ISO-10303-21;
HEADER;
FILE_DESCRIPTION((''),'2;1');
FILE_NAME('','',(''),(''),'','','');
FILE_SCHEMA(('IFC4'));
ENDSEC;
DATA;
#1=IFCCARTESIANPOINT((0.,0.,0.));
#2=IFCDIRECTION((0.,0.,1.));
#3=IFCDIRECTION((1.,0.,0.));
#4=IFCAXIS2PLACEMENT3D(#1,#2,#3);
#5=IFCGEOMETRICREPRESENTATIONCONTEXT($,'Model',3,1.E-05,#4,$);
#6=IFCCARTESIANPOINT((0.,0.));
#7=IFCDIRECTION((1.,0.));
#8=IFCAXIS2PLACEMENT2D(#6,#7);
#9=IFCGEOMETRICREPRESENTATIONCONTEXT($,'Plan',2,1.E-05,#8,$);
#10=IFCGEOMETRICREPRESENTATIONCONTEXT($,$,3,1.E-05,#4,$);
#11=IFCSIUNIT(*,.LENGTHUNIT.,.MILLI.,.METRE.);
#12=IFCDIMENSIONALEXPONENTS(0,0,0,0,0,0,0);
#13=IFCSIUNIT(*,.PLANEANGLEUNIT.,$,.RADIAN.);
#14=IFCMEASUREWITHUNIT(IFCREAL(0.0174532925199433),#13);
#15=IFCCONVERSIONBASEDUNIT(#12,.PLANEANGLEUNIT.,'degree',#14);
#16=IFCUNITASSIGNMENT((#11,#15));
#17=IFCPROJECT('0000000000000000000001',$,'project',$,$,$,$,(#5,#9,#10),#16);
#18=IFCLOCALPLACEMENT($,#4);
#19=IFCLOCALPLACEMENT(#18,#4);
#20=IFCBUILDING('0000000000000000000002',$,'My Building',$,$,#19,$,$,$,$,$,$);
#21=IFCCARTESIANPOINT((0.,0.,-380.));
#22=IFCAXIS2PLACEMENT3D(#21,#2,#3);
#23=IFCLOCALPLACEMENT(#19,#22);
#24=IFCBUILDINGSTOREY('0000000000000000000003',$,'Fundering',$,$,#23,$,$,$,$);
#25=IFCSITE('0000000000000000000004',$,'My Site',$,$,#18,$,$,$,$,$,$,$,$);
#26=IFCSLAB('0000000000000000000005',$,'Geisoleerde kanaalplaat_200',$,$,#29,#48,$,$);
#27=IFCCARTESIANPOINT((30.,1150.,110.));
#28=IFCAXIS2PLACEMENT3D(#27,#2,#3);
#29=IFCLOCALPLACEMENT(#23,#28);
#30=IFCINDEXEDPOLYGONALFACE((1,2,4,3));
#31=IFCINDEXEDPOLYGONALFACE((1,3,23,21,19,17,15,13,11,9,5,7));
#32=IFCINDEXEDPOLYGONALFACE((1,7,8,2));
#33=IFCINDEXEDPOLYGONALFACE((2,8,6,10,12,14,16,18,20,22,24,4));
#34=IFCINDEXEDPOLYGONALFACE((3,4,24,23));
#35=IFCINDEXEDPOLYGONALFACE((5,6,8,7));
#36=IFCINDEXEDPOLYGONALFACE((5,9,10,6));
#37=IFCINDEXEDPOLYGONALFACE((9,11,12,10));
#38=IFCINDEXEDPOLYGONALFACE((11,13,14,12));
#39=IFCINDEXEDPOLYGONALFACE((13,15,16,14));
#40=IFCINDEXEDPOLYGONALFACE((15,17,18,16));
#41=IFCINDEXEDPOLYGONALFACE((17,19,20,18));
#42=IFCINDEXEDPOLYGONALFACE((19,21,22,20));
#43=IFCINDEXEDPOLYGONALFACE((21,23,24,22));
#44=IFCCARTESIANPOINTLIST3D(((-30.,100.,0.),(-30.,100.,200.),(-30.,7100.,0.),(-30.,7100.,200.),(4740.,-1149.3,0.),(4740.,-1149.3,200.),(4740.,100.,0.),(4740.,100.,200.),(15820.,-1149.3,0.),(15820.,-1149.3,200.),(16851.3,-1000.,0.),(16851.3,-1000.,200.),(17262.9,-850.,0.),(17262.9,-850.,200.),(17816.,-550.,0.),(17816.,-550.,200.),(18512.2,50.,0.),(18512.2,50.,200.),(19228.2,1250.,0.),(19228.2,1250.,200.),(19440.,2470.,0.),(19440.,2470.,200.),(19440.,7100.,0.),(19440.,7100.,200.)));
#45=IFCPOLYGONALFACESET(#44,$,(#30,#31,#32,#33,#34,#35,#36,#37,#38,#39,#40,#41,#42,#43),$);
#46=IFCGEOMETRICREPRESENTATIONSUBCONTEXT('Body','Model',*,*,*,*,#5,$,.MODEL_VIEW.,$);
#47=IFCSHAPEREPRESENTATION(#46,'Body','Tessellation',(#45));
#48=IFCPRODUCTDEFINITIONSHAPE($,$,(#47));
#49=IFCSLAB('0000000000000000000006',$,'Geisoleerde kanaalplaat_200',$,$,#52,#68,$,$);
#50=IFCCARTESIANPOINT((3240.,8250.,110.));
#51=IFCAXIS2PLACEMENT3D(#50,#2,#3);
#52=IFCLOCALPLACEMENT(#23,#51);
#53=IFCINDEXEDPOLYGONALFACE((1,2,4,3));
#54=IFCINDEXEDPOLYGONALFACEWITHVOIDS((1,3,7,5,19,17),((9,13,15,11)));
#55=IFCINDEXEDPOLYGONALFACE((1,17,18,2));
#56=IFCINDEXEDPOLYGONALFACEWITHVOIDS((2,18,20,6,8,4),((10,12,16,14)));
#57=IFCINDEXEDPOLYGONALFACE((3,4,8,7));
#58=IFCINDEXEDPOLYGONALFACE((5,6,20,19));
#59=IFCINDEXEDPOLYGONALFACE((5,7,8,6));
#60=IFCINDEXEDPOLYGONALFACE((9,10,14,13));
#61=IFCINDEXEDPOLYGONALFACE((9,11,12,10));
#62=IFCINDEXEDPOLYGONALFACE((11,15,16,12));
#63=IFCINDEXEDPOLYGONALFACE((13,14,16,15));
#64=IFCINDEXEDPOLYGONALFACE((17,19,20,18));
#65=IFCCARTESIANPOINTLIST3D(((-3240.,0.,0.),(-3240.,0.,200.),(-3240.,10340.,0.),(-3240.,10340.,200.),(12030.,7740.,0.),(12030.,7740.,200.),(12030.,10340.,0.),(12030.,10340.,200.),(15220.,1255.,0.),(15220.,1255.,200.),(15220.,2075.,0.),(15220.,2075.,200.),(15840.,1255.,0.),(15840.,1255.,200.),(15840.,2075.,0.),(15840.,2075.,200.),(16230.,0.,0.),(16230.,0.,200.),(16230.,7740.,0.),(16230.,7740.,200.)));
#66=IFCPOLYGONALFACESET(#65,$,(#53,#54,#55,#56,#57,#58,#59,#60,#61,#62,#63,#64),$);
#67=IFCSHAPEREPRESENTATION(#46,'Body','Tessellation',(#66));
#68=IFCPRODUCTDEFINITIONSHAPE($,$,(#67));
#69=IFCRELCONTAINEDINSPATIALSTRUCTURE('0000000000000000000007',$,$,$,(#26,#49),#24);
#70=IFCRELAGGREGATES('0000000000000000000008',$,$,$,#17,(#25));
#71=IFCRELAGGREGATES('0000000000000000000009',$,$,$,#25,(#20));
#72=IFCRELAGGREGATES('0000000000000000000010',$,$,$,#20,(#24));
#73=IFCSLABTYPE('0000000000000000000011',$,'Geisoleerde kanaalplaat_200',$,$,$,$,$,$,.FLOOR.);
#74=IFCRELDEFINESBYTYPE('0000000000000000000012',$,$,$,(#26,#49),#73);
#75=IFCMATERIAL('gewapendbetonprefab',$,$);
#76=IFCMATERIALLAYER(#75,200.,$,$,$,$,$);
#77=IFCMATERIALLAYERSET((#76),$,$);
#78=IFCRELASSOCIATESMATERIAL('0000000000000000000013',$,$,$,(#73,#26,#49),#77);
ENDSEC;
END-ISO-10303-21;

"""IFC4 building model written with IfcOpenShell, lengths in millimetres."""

from ifc_helpers import new_model, entity, si_unit, converted_unit, frame, origin_with_axes, origin_2d_with_axis, place, context, subcontext, project, spatial, line, indexed_curve, outline, extrude, material, layer, layer_set, layer_usage, type_object, element, save


model = new_model("IFC4")

# Units and contexts
model_context = context("Model", 3, precision=1e-05, world=origin_with_axes())
plan_context = context("Plan", 2, precision=1e-05, world=origin_2d_with_axis())
context_of_model = context(None, 3, precision=1e-05, world=origin_with_axes())
body_context = subcontext(model_context, "Body", "Model", "MODEL_VIEW")
ifc_project = project(units=[si_unit("LENGTHUNIT", "METRE", prefix="MILLI"), converted_unit("PLANEANGLEUNIT", "degree", entity("IfcReal", 0.0174532925199433), si_unit("PLANEANGLEUNIT", "RADIAN"), dimensions=[0, 0, 0, 0, 0, 0, 0])], contexts=[model_context, plan_context, context_of_model])

# Site, building, storey
site_placement = place(None, origin_with_axes())
site = spatial("IfcSite", under=ifc_project, at=site_placement, Name="My Site")
building_placement = place(site_placement, origin_with_axes())
building = spatial("IfcBuilding", under=site, at=building_placement, Name="My Building")
storey_placement = place(building_placement, frame((0.0, 0.0, -380.0), z_axis=(0.0, 0.0, 1.0), x_axis=(1.0, 0.0, 0.0)))
storey = spatial("IfcBuildingStorey", under=building, at=storey_placement, Name="Fundering")

# Shared definitions
ifc_material_1 = material(Name="gewapendbetonprefab")

# Slabs
ifc_layer = layer(ifc_material_1, 200.0)
ifc_layer_set = layer_set([ifc_layer])
ifc_layer_usage_1 = layer_usage(ifc_layer_set, "AXIS3", "POSITIVE", 0.0)
slab_type = type_object("IfcSlabType", Name="Geisoleerde kanaalplaat_200", PredefinedType="FLOOR", material=ifc_layer_set)
slab_1_placement = place(storey_placement, frame((30.0, 1150.0, 110.0), z_axis=(0.0, 0.0, 1.0), x_axis=(1.0, 0.0, 0.0)))
element("IfcSlab", 1, at=slab_1_placement, inside=storey, type_object=slab_type, material=ifc_layer_usage_1, Name="Geisoleerde kanaalplaat_200", context=body_context, shape_type="SweptSolid", body=[
    extrude(outline(indexed_curve([(4740.0, -1149.3), (15820.0, -1149.3), (16851.3, -1000.0), (17262.9, -850.0), (17816.0, -550.0), (18512.2, 50.0), (19228.2, 1250.0), (19440.0, 2470.0), (19440.0, 7100.0), (-30.0, 7100.0), (-30.0, 100.0), (4740.0, 100.0)], segments=[line(2, 1), line(1, 12), line(12, 11), line(11, 10), line(10, 9), line(9, 8), line(8, 7), line(7, 6), line(6, 5), line(5, 4), line(4, 3), line(3, 2)], self_intersect=False)), None, (0.0, 0.0, 1.0), 200.0),
])
ifc_layer_usage_2 = layer_usage(ifc_layer_set, "AXIS3", "POSITIVE", 0.0)
slab_2_placement = place(storey_placement, frame((3240.0, 8250.0, 110.0), z_axis=(0.0, 0.0, 1.0), x_axis=(1.0, 0.0, 0.0)))
element("IfcSlab", 2, at=slab_2_placement, inside=storey, type_object=slab_type, material=ifc_layer_usage_2, Name="Geisoleerde kanaalplaat_200", context=body_context, shape_type="SweptSolid", body=[
    extrude(outline(indexed_curve([(16230.0, 0.0), (-3240.0, 0.0), (-3240.0, 10340.0), (12030.0, 10340.0), (12030.0, 7740.0), (16230.0, 7740.0), (15840.0, 1255.0), (15220.0, 1255.0), (15220.0, 2075.0), (15840.0, 2075.0)], segments=[line(1, 6), line(6, 5), line(5, 4), line(4, 3), line(3, 2), line(2, 1)], self_intersect=False), holes=[indexed_curve([(16230.0, 0.0), (-3240.0, 0.0), (-3240.0, 10340.0), (12030.0, 10340.0), (12030.0, 7740.0), (16230.0, 7740.0), (15840.0, 1255.0), (15220.0, 1255.0), (15220.0, 2075.0), (15840.0, 2075.0)], segments=[line(8, 7), line(7, 10), line(10, 9), line(9, 8)], self_intersect=False)]), None, (0.0, 0.0, 1.0), 200.0),
])

save(model, "model.ifc")
